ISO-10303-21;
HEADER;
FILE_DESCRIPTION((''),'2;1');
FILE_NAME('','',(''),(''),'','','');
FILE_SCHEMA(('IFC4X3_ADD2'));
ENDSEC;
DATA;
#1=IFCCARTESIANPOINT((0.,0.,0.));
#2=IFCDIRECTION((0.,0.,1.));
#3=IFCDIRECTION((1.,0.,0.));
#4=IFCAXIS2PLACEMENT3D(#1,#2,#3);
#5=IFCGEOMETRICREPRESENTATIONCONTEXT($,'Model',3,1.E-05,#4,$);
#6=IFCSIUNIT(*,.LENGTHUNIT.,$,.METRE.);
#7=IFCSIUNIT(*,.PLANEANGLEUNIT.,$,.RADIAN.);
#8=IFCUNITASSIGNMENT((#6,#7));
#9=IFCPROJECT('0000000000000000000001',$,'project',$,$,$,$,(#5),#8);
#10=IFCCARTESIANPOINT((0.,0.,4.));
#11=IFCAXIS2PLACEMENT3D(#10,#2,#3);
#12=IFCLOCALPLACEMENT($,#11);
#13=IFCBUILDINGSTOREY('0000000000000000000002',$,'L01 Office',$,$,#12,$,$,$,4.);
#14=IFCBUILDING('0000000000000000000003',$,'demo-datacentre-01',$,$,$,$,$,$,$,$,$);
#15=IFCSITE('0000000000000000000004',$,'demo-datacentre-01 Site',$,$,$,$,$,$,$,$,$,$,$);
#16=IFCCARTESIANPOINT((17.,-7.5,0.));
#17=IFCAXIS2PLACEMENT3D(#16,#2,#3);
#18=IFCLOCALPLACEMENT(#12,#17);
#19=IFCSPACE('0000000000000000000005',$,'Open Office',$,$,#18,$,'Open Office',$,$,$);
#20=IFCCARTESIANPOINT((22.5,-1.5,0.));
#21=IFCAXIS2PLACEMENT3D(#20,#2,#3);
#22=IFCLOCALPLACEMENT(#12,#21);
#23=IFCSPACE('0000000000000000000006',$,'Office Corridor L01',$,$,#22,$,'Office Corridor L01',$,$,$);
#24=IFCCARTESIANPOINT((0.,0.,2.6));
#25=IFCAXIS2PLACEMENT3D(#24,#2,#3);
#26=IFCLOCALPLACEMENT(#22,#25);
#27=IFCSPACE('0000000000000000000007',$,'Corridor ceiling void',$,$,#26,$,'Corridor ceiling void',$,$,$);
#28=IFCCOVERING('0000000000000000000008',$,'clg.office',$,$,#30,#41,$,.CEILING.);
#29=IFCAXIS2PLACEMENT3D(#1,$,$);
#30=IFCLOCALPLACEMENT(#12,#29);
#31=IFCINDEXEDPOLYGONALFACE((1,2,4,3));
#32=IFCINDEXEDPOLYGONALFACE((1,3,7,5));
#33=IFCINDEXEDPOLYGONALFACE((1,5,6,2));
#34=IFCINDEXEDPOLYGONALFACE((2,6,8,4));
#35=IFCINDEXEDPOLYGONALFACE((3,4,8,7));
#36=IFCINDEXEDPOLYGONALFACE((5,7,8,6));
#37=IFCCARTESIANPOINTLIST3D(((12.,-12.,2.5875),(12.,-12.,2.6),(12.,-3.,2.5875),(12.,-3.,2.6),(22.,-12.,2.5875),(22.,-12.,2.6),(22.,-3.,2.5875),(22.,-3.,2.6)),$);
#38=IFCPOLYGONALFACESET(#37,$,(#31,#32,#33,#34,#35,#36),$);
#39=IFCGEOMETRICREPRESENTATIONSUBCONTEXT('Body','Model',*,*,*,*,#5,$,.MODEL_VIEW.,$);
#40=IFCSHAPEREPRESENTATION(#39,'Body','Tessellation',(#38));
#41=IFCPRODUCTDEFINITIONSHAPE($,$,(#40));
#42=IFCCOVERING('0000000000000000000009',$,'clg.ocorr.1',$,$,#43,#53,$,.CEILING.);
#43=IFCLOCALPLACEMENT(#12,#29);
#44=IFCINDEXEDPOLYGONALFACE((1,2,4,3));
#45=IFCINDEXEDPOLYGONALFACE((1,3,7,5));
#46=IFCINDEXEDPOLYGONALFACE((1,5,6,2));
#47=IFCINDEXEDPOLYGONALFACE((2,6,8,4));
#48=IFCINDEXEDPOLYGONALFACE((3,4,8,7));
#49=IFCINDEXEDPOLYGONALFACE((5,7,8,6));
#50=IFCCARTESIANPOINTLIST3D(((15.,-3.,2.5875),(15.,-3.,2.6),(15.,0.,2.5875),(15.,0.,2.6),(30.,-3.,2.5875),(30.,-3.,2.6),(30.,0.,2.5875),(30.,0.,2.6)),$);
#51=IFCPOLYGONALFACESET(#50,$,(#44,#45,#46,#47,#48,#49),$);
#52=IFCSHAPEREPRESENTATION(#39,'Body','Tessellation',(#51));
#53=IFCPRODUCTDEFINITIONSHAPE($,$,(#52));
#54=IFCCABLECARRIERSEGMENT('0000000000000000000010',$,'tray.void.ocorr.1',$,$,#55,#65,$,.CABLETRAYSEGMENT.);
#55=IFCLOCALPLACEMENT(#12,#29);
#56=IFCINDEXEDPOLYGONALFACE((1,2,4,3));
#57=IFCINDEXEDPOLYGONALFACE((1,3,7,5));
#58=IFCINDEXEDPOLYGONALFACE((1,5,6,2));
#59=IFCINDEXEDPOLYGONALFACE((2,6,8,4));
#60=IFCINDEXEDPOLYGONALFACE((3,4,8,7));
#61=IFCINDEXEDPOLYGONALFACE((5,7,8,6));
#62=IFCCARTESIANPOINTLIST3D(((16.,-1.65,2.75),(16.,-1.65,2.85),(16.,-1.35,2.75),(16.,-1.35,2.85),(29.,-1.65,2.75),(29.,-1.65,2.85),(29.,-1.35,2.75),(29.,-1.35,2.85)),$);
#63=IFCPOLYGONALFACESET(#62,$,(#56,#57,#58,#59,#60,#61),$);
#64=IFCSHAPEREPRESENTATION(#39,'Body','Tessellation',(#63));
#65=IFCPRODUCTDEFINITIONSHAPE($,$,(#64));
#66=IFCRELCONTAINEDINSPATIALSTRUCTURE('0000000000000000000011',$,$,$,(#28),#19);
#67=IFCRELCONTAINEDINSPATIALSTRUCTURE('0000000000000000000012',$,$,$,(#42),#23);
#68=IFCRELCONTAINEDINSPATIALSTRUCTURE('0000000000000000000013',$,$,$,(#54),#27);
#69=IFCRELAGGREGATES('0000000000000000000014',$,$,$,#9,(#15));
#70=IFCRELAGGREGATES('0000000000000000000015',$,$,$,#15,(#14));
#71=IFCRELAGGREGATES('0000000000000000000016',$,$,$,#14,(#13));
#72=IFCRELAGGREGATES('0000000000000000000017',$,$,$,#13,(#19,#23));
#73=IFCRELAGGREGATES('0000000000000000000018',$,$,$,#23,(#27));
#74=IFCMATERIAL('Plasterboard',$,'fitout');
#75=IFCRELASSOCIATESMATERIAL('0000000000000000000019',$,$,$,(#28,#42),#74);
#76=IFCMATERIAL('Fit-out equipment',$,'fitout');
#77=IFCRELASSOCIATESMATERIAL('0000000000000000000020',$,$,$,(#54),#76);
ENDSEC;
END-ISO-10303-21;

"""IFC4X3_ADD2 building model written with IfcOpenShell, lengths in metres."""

from ifc_helpers import new_model, si_unit, frame, origin_with_axes, place, context, subcontext, project, spatial, rectangle, extrude, material, element, save


model = new_model("IFC4X3_ADD2")

# Units and contexts
model_context = context("Model", 3, precision=1e-05, world=origin_with_axes())
body_context = subcontext(model_context, "Body", "Model", "MODEL_VIEW")
ifc_project = project(units=[si_unit("LENGTHUNIT", "METRE"), si_unit("PLANEANGLEUNIT", "RADIAN")], contexts=[model_context])

# Site, building, storey, space
site = spatial("IfcSite", under=ifc_project, Name="demo-datacentre-01 Site")
building = spatial("IfcBuilding", under=site, Name="demo-datacentre-01")
storey_placement = place(None, frame((0.0, 0.0, 4.0), z_axis=(0.0, 0.0, 1.0), x_axis=(1.0, 0.0, 0.0)))
storey = spatial("IfcBuildingStorey", under=building, at=storey_placement, Name="L01 Office", Elevation=4.0)
space_1_placement = place(storey_placement, frame((17.0, -7.5, 0.0), z_axis=(0.0, 0.0, 1.0), x_axis=(1.0, 0.0, 0.0)))
space_1 = spatial("IfcSpace", under=storey, at=space_1_placement, Name="Open Office", LongName="Open Office")

# Covering
ifc_material_1 = material(Name="Plasterboard", Category="fitout")
covering_1_placement = place(space_1_placement, frame((0.0, 0.0, 2.5875), z_axis=(0.0, 0.0, 1.0), x_axis=(1.0, 0.0, 0.0)))
element("IfcCovering", 1, at=covering_1_placement, inside=space_1, material=ifc_material_1, Name="clg.office", PredefinedType="CEILING", context=body_context, shape_type="SweptSolid", body=[
    extrude(rectangle(XDim=10.0, YDim=9.0), origin_with_axes(), (0.0, 0.0, 1.0), 0.0125),
])

# Shared definitions
space_2_placement = place(storey_placement, frame((22.5, -1.5, 0.0), z_axis=(0.0, 0.0, 1.0), x_axis=(1.0, 0.0, 0.0)))
space_2 = spatial("IfcSpace", under=storey, at=space_2_placement, Name="Office Corridor L01", LongName="Office Corridor L01")

# Covering
covering_2_placement = place(space_2_placement, frame((0.0, 0.0, 2.5875), z_axis=(0.0, 0.0, 1.0), x_axis=(1.0, 0.0, 0.0)))
element("IfcCovering", 2, at=covering_2_placement, inside=space_2, material=ifc_material_1, Name="clg.ocorr.1", PredefinedType="CEILING", context=body_context, shape_type="SweptSolid", body=[
    extrude(rectangle(XDim=15.0, YDim=3.0), origin_with_axes(), (0.0, 0.0, 1.0), 0.0125),
])

# Shared definitions
space_3_placement = place(space_2_placement, frame((0.0, 0.0, 2.6), z_axis=(0.0, 0.0, 1.0), x_axis=(1.0, 0.0, 0.0)))
space_3 = spatial("IfcSpace", under=space_2, at=space_3_placement, Name="Corridor ceiling void", LongName="Corridor ceiling void")

# Cable carrier segment
ifc_material_2 = material(Name="Fit-out equipment", Category="fitout")
cable_carrier_segment_1_placement = place(space_3_placement, frame((-22.5, 1.5, -6.6), z_axis=(0.0, 0.0, 1.0), x_axis=(1.0, 0.0, 0.0)))
element("IfcCableCarrierSegment", 3, at=cable_carrier_segment_1_placement, inside=space_3, material=ifc_material_2, Name="tray.void.ocorr.1", PredefinedType="CABLETRAYSEGMENT", context=body_context, shape_type="SweptSolid", body=[
    extrude(rectangle(XDim=0.3, YDim=0.1), frame((16.0, -1.5, 6.8), z_axis=(1.0, 0.0, 0.0), x_axis=(0.0, 1.0, 0.0)), (0.0, 0.0, 1.0), 13.0),
])

save(model, "model.ifc")
